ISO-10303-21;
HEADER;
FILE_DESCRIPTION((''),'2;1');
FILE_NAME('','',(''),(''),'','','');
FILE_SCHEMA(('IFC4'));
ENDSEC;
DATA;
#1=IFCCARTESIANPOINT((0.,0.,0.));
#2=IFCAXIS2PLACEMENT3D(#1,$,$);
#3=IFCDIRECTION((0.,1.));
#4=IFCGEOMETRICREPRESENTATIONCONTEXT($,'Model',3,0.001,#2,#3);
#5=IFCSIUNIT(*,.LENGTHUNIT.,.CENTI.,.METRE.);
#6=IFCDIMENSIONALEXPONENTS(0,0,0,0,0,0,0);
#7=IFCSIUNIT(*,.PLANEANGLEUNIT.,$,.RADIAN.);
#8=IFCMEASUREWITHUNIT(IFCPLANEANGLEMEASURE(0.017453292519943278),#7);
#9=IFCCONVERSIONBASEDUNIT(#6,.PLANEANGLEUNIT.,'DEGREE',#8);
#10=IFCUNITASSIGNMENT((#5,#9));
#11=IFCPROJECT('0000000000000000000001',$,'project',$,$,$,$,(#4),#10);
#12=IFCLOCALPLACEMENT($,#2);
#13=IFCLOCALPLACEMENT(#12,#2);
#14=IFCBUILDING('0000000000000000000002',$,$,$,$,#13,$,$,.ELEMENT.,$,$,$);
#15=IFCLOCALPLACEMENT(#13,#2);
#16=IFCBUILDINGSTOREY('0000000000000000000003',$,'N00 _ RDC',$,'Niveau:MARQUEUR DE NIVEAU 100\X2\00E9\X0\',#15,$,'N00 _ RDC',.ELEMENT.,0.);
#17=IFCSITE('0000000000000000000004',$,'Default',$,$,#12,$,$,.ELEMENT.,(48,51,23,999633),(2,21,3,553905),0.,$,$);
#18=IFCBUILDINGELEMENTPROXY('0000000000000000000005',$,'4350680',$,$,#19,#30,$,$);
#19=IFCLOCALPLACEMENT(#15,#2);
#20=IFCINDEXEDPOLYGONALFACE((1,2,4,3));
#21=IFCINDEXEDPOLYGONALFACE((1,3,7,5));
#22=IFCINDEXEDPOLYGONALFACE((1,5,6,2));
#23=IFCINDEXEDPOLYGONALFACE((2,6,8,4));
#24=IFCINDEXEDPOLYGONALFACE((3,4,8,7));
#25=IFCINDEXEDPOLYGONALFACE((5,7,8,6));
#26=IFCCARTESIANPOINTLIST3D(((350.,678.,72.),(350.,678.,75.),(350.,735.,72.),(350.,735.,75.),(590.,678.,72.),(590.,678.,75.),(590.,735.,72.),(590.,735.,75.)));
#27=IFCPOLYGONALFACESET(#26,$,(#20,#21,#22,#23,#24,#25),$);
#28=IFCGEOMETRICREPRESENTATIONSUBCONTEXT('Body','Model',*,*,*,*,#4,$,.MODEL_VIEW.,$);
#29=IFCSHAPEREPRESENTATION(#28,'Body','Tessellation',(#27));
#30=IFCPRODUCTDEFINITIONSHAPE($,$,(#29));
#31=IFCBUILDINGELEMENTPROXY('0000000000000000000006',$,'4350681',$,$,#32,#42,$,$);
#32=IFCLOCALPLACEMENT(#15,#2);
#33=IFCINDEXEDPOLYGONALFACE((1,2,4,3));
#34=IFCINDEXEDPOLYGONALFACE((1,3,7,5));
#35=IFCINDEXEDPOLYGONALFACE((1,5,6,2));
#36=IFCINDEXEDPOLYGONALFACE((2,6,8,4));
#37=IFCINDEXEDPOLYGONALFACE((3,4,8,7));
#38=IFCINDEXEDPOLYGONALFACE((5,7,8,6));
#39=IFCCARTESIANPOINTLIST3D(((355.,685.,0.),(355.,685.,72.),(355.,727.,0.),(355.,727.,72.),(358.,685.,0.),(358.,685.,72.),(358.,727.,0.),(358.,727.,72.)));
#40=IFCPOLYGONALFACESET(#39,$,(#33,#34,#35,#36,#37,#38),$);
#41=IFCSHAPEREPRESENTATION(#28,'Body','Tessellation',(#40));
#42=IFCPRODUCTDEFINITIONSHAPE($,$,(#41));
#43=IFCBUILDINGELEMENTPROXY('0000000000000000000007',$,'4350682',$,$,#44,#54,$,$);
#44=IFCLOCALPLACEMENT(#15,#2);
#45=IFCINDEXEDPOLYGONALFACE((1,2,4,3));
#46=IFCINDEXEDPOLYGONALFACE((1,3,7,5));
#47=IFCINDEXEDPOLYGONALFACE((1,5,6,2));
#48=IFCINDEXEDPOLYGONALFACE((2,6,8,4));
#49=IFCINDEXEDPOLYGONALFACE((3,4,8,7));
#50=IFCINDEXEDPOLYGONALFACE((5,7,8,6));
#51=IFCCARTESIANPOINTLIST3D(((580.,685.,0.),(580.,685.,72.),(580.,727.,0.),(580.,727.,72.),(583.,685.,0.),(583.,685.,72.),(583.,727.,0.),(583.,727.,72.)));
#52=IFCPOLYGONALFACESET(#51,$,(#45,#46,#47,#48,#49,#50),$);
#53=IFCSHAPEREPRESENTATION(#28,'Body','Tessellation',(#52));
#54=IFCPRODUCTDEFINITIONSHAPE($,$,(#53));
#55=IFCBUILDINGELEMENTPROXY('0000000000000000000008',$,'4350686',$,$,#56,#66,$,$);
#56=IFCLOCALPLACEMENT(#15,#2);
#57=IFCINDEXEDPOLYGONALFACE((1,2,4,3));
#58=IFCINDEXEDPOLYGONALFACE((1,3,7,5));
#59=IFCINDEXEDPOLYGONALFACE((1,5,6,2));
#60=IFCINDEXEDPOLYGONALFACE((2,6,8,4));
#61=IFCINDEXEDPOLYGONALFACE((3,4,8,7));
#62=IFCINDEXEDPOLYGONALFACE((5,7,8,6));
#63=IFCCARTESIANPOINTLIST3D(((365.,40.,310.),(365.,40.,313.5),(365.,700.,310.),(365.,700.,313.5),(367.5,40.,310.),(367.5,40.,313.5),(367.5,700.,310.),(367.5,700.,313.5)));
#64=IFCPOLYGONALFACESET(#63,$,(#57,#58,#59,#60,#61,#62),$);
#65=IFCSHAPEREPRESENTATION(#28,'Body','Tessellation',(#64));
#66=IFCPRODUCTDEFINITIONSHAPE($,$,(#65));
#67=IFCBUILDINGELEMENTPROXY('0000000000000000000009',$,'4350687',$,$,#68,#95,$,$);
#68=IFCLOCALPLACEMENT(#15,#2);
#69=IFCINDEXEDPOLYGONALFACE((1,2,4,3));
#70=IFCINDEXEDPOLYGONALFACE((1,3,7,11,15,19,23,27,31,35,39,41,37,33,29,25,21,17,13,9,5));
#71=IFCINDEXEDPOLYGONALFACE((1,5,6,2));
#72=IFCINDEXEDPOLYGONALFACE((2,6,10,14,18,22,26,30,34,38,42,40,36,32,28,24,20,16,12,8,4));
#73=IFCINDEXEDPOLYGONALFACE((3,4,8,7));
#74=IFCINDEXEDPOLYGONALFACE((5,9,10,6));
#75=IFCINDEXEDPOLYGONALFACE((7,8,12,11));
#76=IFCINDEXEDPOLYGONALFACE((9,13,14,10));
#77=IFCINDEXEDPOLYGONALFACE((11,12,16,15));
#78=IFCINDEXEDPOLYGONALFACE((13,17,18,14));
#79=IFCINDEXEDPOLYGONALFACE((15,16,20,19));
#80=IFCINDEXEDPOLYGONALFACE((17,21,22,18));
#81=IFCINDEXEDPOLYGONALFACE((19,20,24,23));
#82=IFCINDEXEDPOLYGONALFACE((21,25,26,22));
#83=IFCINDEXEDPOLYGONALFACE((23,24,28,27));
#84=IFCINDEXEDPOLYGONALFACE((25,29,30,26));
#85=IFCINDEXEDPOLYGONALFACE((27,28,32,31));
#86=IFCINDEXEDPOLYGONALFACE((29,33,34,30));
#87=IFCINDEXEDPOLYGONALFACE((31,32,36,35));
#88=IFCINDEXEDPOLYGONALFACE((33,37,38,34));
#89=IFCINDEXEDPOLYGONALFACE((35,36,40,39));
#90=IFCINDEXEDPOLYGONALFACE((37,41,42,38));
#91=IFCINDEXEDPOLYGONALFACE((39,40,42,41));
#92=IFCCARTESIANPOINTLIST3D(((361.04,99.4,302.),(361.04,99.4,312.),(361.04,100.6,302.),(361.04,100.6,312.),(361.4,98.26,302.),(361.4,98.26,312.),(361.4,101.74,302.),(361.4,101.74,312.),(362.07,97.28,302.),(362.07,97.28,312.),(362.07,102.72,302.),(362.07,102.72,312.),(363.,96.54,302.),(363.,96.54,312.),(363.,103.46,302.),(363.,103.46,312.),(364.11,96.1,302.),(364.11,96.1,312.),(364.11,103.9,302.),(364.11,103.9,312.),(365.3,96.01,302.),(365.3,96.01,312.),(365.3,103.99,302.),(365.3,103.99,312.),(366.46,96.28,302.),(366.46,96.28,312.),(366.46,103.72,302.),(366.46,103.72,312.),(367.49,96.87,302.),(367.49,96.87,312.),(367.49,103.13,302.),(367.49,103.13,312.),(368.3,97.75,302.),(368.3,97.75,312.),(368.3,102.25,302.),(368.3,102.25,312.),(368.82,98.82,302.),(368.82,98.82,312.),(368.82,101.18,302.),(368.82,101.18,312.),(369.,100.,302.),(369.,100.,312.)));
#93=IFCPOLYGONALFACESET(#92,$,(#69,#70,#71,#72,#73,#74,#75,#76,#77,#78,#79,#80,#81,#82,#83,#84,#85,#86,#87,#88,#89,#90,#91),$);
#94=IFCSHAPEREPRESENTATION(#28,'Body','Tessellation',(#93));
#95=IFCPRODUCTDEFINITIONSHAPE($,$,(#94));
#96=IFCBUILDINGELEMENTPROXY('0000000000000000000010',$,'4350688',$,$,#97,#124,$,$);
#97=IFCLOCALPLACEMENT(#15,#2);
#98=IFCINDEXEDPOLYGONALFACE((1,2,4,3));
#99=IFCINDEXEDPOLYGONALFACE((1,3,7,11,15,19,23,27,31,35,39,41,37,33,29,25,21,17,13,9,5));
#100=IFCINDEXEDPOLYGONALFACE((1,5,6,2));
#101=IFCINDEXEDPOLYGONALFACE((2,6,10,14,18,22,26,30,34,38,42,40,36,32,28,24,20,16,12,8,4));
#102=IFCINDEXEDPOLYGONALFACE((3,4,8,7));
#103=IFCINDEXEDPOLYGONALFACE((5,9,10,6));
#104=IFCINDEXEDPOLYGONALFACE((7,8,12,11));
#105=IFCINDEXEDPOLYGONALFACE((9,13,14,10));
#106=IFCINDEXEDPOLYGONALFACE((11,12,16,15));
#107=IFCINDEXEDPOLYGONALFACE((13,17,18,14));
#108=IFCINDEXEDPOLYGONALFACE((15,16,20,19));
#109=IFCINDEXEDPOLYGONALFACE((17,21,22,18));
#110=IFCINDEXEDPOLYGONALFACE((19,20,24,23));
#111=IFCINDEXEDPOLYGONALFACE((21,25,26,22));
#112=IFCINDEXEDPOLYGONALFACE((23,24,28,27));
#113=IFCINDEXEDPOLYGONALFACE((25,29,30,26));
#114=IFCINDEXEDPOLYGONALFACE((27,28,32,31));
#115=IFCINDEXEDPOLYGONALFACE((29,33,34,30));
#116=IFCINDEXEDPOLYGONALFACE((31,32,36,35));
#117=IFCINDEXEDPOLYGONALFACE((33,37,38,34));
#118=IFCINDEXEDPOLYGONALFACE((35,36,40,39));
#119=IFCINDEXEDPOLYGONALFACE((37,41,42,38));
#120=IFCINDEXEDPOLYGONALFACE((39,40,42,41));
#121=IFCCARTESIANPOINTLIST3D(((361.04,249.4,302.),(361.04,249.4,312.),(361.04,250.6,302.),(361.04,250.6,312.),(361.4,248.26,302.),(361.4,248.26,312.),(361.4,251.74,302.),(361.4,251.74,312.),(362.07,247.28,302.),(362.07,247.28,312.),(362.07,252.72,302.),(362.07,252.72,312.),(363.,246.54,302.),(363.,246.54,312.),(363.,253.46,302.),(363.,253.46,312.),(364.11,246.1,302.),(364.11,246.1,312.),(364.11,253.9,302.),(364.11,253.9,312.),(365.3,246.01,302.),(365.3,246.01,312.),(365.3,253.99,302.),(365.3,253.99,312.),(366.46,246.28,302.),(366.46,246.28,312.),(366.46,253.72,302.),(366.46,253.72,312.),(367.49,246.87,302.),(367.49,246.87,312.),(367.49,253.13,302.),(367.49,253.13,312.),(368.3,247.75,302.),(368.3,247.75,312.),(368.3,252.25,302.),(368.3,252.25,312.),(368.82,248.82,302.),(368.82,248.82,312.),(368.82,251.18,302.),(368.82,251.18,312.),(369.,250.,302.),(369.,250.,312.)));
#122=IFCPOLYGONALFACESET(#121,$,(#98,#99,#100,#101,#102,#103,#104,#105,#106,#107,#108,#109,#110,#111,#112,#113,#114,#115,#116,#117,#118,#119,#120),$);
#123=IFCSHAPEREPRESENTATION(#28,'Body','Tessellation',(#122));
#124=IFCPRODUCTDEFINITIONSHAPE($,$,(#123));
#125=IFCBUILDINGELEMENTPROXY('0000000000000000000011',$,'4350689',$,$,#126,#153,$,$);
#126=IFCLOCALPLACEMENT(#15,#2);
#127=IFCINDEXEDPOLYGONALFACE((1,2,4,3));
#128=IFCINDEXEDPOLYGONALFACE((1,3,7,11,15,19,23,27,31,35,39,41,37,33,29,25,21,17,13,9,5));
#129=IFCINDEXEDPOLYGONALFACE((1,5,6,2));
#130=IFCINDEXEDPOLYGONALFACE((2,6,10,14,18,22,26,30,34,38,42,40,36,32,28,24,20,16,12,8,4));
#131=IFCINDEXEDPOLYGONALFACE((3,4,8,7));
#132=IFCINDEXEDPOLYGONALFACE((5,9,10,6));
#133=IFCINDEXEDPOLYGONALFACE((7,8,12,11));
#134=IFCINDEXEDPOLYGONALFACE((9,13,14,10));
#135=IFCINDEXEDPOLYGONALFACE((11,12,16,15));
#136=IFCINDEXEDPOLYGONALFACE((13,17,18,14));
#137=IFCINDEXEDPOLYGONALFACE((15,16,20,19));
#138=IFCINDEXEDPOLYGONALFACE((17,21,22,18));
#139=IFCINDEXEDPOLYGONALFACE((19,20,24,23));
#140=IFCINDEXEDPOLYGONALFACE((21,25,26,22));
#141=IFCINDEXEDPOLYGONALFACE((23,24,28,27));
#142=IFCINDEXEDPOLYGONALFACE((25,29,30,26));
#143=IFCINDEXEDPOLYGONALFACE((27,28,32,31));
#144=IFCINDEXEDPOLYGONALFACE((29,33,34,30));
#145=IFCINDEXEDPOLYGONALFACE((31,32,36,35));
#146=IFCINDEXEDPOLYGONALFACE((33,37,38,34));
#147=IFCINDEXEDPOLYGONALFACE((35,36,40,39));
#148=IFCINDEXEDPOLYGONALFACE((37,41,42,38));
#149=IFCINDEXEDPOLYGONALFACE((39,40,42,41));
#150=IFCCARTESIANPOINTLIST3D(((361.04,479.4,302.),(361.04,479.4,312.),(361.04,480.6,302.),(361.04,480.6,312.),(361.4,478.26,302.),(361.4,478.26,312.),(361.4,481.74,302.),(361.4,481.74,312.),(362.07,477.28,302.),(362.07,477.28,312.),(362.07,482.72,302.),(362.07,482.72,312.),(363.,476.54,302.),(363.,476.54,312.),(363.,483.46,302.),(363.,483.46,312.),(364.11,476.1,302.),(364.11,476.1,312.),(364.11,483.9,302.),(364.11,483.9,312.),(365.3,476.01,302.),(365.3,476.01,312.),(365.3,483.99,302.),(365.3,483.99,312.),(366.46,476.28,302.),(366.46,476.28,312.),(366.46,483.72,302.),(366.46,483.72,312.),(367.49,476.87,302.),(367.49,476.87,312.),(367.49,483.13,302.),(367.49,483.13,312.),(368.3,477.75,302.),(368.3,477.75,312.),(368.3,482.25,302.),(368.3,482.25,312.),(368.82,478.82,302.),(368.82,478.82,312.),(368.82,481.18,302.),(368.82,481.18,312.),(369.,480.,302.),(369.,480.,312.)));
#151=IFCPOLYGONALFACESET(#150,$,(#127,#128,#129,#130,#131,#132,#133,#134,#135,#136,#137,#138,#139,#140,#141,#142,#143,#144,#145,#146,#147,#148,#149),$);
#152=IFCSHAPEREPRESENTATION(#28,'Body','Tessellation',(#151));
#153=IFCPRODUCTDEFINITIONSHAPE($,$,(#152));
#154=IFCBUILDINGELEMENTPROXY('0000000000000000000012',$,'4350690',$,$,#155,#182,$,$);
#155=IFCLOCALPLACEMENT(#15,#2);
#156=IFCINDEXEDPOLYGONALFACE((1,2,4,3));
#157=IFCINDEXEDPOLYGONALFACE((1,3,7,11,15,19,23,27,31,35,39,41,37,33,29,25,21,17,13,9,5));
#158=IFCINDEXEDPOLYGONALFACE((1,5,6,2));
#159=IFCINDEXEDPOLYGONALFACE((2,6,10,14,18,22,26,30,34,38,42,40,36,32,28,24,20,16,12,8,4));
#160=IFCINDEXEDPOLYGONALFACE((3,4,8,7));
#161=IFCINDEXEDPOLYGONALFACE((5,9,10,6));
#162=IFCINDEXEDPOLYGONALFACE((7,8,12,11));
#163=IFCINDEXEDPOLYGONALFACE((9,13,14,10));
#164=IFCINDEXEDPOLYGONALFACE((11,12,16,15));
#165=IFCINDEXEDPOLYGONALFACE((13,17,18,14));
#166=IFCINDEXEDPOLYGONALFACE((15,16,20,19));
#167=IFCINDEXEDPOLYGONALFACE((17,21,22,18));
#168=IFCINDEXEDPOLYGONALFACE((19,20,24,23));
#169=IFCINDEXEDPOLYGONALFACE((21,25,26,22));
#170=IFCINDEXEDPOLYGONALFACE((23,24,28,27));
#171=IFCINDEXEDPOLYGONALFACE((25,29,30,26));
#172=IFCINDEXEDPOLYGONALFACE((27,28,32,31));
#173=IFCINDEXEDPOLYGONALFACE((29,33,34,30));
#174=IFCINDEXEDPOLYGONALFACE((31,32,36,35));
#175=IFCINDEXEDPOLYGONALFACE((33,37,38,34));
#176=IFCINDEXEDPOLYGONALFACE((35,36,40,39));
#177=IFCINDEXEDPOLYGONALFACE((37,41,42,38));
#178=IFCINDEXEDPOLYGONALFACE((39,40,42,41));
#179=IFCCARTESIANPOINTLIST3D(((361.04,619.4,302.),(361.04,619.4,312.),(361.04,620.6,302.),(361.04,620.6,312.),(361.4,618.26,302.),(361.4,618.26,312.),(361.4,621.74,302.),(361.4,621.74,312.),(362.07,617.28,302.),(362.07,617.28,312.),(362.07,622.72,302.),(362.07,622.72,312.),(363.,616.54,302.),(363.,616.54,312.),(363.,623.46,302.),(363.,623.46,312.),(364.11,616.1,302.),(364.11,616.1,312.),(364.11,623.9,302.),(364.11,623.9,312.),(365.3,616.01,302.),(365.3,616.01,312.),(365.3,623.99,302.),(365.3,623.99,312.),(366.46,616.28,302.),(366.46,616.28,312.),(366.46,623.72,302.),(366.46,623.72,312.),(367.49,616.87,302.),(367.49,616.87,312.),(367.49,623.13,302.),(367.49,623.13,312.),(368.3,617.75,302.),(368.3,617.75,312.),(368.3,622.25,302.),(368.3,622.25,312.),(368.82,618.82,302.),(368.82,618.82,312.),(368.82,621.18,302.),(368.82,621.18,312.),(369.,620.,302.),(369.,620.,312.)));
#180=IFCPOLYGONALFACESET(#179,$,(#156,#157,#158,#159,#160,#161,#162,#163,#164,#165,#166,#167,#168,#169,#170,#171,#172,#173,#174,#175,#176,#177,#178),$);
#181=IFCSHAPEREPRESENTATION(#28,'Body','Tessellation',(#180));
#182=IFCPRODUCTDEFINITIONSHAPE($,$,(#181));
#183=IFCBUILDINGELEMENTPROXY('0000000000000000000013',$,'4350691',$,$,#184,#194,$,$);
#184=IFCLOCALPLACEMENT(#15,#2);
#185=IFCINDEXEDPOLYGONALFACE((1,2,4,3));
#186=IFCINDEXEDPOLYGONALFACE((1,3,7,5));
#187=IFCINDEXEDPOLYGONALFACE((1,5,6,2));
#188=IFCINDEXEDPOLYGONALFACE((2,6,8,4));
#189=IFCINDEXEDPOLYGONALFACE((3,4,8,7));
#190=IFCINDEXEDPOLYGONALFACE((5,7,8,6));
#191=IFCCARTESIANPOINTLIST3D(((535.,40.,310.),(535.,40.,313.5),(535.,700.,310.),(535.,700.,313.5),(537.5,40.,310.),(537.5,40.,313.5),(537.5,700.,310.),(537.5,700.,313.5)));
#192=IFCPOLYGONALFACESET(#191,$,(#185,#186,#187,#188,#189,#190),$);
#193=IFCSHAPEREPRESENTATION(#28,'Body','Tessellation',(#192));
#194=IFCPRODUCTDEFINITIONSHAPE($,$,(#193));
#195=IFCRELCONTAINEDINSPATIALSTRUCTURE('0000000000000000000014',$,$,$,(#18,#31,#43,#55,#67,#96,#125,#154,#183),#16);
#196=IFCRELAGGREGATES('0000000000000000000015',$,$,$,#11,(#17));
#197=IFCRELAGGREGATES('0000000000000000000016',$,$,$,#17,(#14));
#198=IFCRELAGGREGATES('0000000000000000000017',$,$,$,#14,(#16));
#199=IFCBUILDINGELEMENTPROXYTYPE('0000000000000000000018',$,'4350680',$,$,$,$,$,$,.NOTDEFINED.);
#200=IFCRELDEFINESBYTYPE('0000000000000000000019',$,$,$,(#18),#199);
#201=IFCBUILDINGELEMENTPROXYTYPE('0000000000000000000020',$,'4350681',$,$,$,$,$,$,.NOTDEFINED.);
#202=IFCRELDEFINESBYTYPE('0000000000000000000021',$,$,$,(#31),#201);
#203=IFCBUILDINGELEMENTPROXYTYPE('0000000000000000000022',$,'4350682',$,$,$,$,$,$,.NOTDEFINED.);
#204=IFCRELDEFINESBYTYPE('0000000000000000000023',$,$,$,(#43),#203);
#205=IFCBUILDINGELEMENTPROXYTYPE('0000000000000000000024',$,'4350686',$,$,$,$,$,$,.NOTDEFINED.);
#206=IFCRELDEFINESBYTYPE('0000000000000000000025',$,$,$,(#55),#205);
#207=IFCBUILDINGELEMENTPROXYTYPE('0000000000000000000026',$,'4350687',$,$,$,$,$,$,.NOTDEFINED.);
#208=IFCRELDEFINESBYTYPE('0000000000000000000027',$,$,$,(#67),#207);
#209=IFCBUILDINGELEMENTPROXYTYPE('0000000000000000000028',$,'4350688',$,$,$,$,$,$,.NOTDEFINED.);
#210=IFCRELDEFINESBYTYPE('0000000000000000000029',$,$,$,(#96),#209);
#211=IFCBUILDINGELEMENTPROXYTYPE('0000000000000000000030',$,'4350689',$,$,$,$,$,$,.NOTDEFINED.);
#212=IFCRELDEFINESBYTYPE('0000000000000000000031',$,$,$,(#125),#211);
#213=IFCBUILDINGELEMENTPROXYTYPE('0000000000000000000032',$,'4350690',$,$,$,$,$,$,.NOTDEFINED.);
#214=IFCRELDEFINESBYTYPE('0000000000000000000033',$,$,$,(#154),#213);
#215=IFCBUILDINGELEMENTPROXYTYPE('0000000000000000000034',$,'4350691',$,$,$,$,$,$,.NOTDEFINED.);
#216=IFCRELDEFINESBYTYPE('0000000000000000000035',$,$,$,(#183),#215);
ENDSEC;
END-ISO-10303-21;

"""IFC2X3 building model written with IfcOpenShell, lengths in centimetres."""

from ifc_helpers import new_model, entity, si_unit, converted_unit, direction, frame, frame_2d, origin, origin_2d_with_axis, place, context, subcontext, project, spatial, rectangle, circle, extrude, type_object, element, save


model = new_model("IFC2X3")

# Units and contexts
model_context = context("Model", 3, precision=0.001, world=origin(), true_north=direction((0.0, 1.0)))
body_context = subcontext(model_context, "Body", "Model", "MODEL_VIEW")
ifc_project = project(units=[si_unit("LENGTHUNIT", "METRE", prefix="CENTI"), converted_unit("PLANEANGLEUNIT", "DEGREE", entity("IfcPlaneAngleMeasure", 0.017453292519943278), si_unit("PLANEANGLEUNIT", "RADIAN"), dimensions=[0, 0, 0, 0, 0, 0, 0])], contexts=[model_context])

# Site, building, storey
site_placement = place(None, origin())
site = spatial("IfcSite", under=ifc_project, at=site_placement, Name="Default", CompositionType="ELEMENT", RefLatitude=(48, 51, 23, 999633), RefLongitude=(2, 21, 3, 553905), RefElevation=0.0)
building_placement = place(site_placement, origin())
building = spatial("IfcBuilding", under=site, at=building_placement, CompositionType="ELEMENT")
storey_placement = place(building_placement, origin())
storey = spatial("IfcBuildingStorey", under=building, at=storey_placement, Name="N00 _ RDC", ObjectType="Niveau:MARQUEUR DE NIVEAU 100é", LongName="N00 _ RDC", CompositionType="ELEMENT", Elevation=0.0)

# Building element proxies
building_element_proxy_type_1 = type_object("IfcBuildingElementProxyType", Name="4350680", PredefinedType="NOTDEFINED")
proxy_1_placement = place(storey_placement, origin())
element("IfcBuildingElementProxy", 1, at=proxy_1_placement, inside=storey, type_object=building_element_proxy_type_1, Name="4350680", context=body_context, shape_type="SweptSolid", body=[
    extrude(rectangle(XDim=240.0, YDim=57.0, at=frame_2d((0.0, 0.0), x_axis=(1.0, 0.0))), frame((470.0, 706.5, 72.0)), (0.0, 0.0, 1.0), 3.0),
])
building_element_proxy_type_2 = type_object("IfcBuildingElementProxyType", Name="4350681", PredefinedType="NOTDEFINED")
proxy_2_placement = place(storey_placement, origin())
element("IfcBuildingElementProxy", 2, at=proxy_2_placement, inside=storey, type_object=building_element_proxy_type_2, Name="4350681", context=body_context, shape_type="SweptSolid", body=[
    extrude(rectangle(XDim=3.0, YDim=42.0, at=origin_2d_with_axis()), frame((356.5, 706.0, 0.0)), (0.0, 0.0, 1.0), 72.0),
])
building_element_proxy_type_3 = type_object("IfcBuildingElementProxyType", Name="4350682", PredefinedType="NOTDEFINED")
proxy_3_placement = place(storey_placement, origin())
element("IfcBuildingElementProxy", 3, at=proxy_3_placement, inside=storey, type_object=building_element_proxy_type_3, Name="4350682", context=body_context, shape_type="SweptSolid", body=[
    extrude(rectangle(XDim=3.0, YDim=42.0, at=frame_2d((0.0, 0.0), x_axis=(1.0, 0.0))), frame((581.5, 706.0, 0.0)), (0.0, 0.0, 1.0), 72.0),
])
building_element_proxy_type_4 = type_object("IfcBuildingElementProxyType", Name="4350686", PredefinedType="NOTDEFINED")
proxy_4_placement = place(storey_placement, origin())
element("IfcBuildingElementProxy", 4, at=proxy_4_placement, inside=storey, type_object=building_element_proxy_type_4, Name="4350686", context=body_context, shape_type="SweptSolid", body=[
    extrude(rectangle(XDim=2.5, YDim=660.0, at=frame_2d((0.0, 0.0), x_axis=(1.0, 0.0))), frame((366.25, 370.0, 310.0)), (0.0, 0.0, 1.0), 3.5),
])
building_element_proxy_type_5 = type_object("IfcBuildingElementProxyType", Name="4350687", PredefinedType="NOTDEFINED")
proxy_5_placement = place(storey_placement, origin())
element("IfcBuildingElementProxy", 5, at=proxy_5_placement, inside=storey, type_object=building_element_proxy_type_5, Name="4350687", context=body_context, shape_type="SweptSolid", body=[
    extrude(circle(Radius=4.0, at=origin_2d_with_axis()), frame((365.0, 100.0, 302.0)), (0.0, 0.0, 1.0), 10.0),
])
building_element_proxy_type_6 = type_object("IfcBuildingElementProxyType", Name="4350688", PredefinedType="NOTDEFINED")
proxy_6_placement = place(storey_placement, origin())
element("IfcBuildingElementProxy", 6, at=proxy_6_placement, inside=storey, type_object=building_element_proxy_type_6, Name="4350688", context=body_context, shape_type="SweptSolid", body=[
    extrude(circle(Radius=4.0, at=origin_2d_with_axis()), frame((365.0, 250.0, 302.0)), (0.0, 0.0, 1.0), 10.0),
])
building_element_proxy_type_7 = type_object("IfcBuildingElementProxyType", Name="4350689", PredefinedType="NOTDEFINED")
proxy_7_placement = place(storey_placement, origin())
element("IfcBuildingElementProxy", 7, at=proxy_7_placement, inside=storey, type_object=building_element_proxy_type_7, Name="4350689", context=body_context, shape_type="SweptSolid", body=[
    extrude(circle(Radius=4.0, at=origin_2d_with_axis()), frame((365.0, 480.0, 302.0)), (0.0, 0.0, 1.0), 10.0),
])
building_element_proxy_type_8 = type_object("IfcBuildingElementProxyType", Name="4350690", PredefinedType="NOTDEFINED")
proxy_8_placement = place(storey_placement, origin())
element("IfcBuildingElementProxy", 8, at=proxy_8_placement, inside=storey, type_object=building_element_proxy_type_8, Name="4350690", context=body_context, shape_type="SweptSolid", body=[
    extrude(circle(Radius=4.0, at=origin_2d_with_axis()), frame((365.0, 620.0, 302.0)), (0.0, 0.0, 1.0), 10.0),
])
building_element_proxy_type_9 = type_object("IfcBuildingElementProxyType", Name="4350691", PredefinedType="NOTDEFINED")
proxy_9_placement = place(storey_placement, origin())
element("IfcBuildingElementProxy", 9, at=proxy_9_placement, inside=storey, type_object=building_element_proxy_type_9, Name="4350691", context=body_context, shape_type="SweptSolid", body=[
    extrude(rectangle(XDim=2.5, YDim=660.0, at=frame_2d((0.0, 0.0), x_axis=(1.0, 0.0))), frame((536.25, 370.0, 310.0)), (0.0, 0.0, 1.0), 3.5),
])

save(model, "model.ifc")
